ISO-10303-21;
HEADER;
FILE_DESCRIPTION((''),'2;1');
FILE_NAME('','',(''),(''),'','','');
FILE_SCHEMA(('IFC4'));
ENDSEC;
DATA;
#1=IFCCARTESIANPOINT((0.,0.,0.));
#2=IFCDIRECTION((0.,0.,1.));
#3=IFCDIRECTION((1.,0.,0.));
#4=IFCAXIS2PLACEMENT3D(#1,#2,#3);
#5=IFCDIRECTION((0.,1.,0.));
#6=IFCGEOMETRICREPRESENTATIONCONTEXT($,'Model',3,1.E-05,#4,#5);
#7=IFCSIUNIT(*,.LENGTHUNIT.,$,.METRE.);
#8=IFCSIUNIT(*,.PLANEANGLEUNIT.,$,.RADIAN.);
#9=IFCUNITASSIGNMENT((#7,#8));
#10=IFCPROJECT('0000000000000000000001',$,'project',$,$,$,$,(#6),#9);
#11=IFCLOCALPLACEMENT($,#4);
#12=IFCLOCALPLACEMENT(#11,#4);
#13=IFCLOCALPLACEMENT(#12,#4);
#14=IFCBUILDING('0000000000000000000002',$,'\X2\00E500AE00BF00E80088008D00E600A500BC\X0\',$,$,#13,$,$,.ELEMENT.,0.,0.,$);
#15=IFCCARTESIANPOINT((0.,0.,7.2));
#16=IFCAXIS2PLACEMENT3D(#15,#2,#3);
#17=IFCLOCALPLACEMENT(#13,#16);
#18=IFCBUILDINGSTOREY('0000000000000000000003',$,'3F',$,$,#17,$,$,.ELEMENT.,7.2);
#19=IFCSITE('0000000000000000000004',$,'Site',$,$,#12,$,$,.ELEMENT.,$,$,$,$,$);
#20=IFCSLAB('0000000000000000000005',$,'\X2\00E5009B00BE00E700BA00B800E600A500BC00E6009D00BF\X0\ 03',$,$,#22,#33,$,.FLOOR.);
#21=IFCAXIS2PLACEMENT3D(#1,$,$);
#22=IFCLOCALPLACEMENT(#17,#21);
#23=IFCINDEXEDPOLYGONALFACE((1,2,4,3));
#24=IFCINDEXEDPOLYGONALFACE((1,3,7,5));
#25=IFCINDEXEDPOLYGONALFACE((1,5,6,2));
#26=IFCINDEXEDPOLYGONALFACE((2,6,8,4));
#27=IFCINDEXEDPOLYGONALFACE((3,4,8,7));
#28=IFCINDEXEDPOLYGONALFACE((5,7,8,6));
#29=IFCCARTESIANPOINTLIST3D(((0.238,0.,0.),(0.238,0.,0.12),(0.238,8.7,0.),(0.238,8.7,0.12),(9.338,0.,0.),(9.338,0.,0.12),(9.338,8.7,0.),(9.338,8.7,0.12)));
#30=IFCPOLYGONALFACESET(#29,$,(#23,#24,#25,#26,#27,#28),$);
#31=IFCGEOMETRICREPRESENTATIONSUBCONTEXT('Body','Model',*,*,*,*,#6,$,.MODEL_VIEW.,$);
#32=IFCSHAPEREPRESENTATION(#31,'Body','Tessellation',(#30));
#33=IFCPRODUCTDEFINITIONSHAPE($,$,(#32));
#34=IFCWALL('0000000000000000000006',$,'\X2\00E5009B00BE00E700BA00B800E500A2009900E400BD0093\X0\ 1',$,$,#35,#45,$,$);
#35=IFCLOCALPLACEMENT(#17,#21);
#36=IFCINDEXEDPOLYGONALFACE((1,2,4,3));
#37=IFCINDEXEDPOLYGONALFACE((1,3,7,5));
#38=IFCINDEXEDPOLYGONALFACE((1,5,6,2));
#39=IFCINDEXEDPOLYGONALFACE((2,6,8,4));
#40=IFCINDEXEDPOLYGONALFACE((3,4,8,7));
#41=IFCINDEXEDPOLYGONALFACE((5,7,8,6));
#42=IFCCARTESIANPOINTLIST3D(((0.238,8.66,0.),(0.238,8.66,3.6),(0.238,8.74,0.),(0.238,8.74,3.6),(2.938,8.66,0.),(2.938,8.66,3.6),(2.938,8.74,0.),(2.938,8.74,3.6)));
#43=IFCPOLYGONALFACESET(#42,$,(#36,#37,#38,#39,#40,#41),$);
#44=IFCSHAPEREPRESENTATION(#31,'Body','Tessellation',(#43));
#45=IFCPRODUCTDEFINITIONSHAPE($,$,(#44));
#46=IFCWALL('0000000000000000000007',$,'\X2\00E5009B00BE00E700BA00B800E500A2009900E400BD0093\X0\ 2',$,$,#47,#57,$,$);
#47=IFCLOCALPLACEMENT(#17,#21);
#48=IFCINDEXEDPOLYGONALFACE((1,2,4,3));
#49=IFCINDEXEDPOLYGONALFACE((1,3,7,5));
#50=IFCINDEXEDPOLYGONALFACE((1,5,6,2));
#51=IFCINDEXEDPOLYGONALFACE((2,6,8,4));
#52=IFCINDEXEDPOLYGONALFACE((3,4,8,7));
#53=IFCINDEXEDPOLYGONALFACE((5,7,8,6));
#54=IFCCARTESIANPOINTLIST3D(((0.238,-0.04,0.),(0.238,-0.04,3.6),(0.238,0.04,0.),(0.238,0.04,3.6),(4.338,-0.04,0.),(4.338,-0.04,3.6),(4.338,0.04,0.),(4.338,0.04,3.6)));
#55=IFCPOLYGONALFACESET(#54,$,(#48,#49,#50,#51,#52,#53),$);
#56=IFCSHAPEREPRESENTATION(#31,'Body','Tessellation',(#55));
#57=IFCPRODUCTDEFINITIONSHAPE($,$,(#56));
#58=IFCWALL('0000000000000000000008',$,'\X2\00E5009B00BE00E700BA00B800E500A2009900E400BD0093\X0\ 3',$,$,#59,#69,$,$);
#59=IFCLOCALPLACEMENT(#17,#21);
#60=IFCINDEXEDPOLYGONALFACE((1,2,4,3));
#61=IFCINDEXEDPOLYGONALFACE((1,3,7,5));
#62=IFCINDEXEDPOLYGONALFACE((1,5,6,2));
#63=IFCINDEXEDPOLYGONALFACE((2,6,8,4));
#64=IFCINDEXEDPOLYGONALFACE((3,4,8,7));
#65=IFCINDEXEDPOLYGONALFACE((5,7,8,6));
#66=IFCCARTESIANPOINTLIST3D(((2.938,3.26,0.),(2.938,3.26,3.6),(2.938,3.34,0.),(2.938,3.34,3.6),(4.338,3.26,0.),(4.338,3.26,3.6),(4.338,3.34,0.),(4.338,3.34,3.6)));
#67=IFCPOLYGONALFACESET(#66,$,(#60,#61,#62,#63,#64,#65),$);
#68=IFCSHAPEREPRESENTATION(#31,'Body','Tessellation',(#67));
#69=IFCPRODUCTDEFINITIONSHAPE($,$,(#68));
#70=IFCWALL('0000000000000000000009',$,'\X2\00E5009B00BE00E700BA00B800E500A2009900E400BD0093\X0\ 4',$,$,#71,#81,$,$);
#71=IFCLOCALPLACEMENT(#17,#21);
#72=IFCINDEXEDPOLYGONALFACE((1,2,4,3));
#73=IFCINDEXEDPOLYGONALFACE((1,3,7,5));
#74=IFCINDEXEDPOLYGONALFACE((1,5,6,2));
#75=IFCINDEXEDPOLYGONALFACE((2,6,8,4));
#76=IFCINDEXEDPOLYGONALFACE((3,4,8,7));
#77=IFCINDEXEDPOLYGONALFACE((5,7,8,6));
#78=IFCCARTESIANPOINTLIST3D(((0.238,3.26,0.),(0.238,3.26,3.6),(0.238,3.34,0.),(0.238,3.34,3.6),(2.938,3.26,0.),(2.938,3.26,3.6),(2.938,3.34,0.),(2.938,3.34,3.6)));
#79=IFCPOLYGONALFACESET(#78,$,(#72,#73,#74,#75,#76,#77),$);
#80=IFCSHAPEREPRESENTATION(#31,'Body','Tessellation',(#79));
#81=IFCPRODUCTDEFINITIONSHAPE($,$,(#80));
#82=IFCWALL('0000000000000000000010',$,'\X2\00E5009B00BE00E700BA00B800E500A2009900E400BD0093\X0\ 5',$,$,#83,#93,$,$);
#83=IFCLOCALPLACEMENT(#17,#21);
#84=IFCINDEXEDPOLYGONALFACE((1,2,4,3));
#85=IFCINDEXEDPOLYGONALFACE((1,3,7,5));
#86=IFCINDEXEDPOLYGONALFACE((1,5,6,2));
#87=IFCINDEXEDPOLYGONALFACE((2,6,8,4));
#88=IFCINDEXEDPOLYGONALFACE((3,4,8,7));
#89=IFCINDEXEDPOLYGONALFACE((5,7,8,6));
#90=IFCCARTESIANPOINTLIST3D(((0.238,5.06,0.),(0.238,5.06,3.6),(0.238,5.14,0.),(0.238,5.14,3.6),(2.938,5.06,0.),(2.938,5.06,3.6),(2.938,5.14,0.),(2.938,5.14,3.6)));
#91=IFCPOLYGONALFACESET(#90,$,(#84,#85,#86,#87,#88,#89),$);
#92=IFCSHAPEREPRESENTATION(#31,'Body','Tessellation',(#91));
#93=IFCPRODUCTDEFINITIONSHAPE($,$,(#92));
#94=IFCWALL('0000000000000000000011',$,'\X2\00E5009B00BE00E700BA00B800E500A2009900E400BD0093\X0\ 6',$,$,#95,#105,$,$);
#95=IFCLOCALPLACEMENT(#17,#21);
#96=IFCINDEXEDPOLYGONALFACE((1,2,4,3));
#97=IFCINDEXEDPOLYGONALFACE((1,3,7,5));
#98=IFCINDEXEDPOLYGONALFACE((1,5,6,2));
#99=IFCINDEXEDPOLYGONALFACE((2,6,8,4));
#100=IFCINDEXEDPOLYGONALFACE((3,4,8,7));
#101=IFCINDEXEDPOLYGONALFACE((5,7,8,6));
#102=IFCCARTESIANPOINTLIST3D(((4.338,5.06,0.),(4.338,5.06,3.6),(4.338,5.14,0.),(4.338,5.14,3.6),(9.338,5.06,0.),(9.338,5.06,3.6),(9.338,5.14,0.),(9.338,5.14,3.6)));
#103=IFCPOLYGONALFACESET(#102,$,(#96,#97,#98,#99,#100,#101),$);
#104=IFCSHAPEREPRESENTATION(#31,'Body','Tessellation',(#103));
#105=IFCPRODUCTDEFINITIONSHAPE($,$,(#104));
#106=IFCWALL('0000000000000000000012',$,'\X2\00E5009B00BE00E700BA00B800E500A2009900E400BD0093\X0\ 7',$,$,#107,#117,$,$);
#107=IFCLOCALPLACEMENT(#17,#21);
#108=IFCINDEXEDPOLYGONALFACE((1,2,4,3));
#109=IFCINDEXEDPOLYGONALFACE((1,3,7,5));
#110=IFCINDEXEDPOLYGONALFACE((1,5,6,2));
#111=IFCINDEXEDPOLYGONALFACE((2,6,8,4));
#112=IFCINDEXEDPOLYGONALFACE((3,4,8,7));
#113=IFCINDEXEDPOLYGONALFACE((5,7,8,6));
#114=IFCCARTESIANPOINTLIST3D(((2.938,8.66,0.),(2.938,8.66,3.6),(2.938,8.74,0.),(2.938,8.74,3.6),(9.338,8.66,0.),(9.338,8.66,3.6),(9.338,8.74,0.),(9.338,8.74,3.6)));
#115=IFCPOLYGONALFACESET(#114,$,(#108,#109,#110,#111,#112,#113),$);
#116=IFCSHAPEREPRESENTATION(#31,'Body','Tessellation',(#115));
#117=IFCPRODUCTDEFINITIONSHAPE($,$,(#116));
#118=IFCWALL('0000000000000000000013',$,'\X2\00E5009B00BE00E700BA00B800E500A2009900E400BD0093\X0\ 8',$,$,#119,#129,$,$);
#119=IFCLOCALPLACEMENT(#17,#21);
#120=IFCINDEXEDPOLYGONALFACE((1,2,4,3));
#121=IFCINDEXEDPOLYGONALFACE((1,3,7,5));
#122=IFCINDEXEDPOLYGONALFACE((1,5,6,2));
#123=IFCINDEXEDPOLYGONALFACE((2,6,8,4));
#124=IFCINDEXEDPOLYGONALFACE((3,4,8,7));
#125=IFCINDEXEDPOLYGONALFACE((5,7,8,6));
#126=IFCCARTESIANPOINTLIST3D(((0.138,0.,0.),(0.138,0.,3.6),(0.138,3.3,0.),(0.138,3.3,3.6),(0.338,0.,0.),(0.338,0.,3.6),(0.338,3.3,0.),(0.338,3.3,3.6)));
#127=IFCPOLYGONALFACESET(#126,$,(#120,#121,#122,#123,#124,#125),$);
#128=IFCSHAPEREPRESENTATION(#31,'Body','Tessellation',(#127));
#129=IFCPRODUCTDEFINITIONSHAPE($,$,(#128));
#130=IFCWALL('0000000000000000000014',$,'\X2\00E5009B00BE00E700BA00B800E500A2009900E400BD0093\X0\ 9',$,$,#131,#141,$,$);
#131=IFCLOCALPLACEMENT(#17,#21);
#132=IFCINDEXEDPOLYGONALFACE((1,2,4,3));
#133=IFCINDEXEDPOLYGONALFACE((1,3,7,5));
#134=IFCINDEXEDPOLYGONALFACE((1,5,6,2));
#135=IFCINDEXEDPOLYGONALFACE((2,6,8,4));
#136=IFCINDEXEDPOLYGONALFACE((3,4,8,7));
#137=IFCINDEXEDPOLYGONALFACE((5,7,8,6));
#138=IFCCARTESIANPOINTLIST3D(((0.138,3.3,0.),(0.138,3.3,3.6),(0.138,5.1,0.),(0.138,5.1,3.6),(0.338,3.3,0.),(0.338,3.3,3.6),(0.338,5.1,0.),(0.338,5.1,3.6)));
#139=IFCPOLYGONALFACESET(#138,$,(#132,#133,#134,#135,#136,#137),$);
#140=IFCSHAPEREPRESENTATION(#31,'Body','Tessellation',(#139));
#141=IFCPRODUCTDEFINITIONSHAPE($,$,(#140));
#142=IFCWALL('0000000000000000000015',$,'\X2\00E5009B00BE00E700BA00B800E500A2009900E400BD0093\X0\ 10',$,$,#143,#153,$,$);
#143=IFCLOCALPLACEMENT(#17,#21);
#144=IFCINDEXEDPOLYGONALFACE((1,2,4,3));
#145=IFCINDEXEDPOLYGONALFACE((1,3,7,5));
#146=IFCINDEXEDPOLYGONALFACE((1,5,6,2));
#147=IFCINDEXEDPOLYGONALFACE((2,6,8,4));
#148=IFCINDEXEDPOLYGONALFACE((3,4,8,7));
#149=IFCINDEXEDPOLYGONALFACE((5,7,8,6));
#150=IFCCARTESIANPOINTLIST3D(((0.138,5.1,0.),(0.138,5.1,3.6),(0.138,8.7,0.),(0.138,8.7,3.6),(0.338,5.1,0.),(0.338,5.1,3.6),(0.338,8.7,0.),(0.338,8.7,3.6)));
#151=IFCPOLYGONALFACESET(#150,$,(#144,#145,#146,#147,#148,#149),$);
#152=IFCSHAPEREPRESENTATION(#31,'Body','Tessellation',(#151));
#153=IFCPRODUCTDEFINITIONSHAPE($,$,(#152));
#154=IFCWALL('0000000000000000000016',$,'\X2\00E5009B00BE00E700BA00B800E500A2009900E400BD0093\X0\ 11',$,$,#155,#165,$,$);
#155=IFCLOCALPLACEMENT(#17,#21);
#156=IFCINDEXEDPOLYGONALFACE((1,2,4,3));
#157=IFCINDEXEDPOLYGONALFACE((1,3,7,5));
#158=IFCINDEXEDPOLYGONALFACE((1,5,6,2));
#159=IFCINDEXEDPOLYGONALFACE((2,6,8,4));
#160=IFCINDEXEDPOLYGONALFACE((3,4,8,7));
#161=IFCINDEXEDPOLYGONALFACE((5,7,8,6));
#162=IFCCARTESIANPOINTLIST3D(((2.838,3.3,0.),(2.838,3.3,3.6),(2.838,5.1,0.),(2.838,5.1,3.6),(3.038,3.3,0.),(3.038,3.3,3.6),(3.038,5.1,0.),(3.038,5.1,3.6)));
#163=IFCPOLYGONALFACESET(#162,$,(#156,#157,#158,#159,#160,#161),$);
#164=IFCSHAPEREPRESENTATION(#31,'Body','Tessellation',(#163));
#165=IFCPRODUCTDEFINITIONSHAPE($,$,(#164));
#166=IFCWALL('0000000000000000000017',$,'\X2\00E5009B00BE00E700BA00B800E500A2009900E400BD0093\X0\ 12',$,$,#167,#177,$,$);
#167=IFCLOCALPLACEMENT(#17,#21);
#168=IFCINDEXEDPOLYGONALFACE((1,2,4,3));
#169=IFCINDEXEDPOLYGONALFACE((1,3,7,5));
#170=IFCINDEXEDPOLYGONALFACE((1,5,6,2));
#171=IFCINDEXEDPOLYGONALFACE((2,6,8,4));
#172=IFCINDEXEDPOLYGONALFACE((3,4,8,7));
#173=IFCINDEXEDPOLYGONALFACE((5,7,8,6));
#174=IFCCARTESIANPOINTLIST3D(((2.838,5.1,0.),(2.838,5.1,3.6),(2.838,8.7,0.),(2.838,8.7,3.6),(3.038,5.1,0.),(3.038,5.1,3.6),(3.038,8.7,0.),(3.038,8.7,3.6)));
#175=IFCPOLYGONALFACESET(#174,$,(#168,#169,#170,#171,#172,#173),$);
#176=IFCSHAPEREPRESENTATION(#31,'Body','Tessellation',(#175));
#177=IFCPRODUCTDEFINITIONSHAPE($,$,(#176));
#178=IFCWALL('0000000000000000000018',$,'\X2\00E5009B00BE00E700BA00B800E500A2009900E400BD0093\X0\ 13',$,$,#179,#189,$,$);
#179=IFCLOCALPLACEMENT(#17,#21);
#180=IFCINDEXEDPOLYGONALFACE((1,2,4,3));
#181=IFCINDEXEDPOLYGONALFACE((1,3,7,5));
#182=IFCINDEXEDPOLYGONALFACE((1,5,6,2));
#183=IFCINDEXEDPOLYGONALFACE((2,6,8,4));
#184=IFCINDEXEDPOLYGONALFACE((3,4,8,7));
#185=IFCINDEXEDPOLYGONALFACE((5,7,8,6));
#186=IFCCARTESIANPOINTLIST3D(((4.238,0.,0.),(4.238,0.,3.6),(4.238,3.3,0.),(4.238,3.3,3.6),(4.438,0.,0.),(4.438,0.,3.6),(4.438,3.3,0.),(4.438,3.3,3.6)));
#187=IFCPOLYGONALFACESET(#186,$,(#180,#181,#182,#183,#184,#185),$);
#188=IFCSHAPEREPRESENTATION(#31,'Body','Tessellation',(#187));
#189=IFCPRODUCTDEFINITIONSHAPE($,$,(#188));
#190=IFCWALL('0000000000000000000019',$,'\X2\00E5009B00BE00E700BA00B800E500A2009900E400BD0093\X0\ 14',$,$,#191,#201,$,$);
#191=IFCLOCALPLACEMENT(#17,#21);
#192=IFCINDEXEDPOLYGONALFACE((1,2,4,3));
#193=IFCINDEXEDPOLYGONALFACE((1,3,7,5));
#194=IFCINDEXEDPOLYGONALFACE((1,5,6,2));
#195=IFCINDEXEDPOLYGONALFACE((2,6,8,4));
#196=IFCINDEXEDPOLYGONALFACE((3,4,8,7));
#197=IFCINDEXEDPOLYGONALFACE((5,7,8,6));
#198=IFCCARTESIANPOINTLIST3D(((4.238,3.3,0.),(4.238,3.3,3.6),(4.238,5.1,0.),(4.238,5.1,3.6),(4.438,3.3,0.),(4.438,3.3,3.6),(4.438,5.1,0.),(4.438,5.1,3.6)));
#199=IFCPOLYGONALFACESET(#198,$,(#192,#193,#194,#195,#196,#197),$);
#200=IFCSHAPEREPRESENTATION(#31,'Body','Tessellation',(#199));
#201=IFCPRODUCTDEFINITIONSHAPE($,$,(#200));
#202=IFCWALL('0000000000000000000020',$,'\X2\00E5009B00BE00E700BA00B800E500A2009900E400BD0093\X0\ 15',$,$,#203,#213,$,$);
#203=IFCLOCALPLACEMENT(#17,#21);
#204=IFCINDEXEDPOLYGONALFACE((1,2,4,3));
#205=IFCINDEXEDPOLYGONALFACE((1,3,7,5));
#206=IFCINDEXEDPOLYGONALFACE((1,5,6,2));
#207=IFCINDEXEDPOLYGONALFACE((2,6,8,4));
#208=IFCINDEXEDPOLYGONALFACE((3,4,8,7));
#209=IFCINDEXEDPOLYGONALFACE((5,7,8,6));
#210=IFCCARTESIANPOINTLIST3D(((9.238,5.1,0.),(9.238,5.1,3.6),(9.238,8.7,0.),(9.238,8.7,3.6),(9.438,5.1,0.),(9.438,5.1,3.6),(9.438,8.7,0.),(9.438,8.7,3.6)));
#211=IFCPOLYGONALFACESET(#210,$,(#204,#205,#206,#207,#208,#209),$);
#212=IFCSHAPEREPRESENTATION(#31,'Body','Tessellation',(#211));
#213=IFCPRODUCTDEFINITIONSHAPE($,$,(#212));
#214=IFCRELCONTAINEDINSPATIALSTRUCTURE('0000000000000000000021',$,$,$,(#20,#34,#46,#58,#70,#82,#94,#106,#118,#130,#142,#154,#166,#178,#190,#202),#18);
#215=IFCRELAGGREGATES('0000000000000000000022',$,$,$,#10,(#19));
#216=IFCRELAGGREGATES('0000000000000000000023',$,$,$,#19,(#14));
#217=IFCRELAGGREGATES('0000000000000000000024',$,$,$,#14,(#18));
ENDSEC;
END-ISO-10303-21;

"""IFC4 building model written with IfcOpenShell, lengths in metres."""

from ifc_helpers import new_model, si_unit, direction, frame, frame_2d, origin_with_axes, place, context, subcontext, project, spatial, rectangle, extrude, element, save


model = new_model("IFC4")

# Units and contexts
model_context = context("Model", 3, precision=1e-05, world=origin_with_axes(), true_north=direction((0.0, 1.0, 0.0)))
body_context = subcontext(model_context, "Body", "Model", "MODEL_VIEW")
ifc_project = project(units=[si_unit("LENGTHUNIT", "METRE"), si_unit("PLANEANGLEUNIT", "RADIAN")], contexts=[model_context])

# Site, building, storey
placement = place(None, origin_with_axes())
site_placement = place(placement, origin_with_axes())
site = spatial("IfcSite", under=ifc_project, at=site_placement, Name="Site", CompositionType="ELEMENT")
building_placement = place(site_placement, origin_with_axes())
building = spatial("IfcBuilding", under=site, at=building_placement, Name="å®¿è\u0088\u008dæ¥¼", CompositionType="ELEMENT", ElevationOfRefHeight=0.0, ElevationOfTerrain=0.0)
storey_placement = place(building_placement, frame((0.0, 0.0, 7.2), z_axis=(0.0, 0.0, 1.0), x_axis=(1.0, 0.0, 0.0)))
storey = spatial("IfcBuildingStorey", under=building, at=storey_placement, Name="3F", CompositionType="ELEMENT", Elevation=7.2)

# Slab
slab_placement = place(storey_placement, frame((4.788, 4.35, 0.0), z_axis=(0.0, 0.0, 1.0), x_axis=(1.0, 0.0, 0.0)))
element("IfcSlab", 1, at=slab_placement, inside=storey, Name="å\u009b¾çº¸æ¥¼æ\u009d¿ 03", PredefinedType="FLOOR", context=body_context, shape_type="SweptSolid", body=[
    extrude(rectangle(XDim=9.1, YDim=8.7, at=frame_2d((0.0, 0.0), x_axis=(1.0, 0.0, 0.0))), frame((0.0, 0.0, 0.0), z_axis=(0.0, 0.0, 1.0)), (0.0, 0.0, 1.0), 0.12),
])

# Walls
wall_1_placement = place(storey_placement, frame((1.588, 8.7, 0.0), z_axis=(0.0, 0.0, 1.0), x_axis=(1.0, 0.0, 0.0)))
element("IfcWall", 2, at=wall_1_placement, inside=storey, Name="å\u009b¾çº¸å¢\u0099ä½\u0093 1", context=body_context, shape_type="SweptSolid", body=[
    extrude(rectangle(XDim=2.7, YDim=0.0801, at=frame_2d((0.0, 0.0), x_axis=(1.0, 0.0, 0.0))), frame((0.0, 0.0, 0.0), z_axis=(0.0, 0.0, 1.0)), (0.0, 0.0, 1.0), 3.6),
])
wall_2_placement = place(storey_placement, frame((2.288, 0.0, 0.0), z_axis=(0.0, 0.0, 1.0), x_axis=(1.0, 0.0, 0.0)))
element("IfcWall", 3, at=wall_2_placement, inside=storey, Name="å\u009b¾çº¸å¢\u0099ä½\u0093 2", context=body_context, shape_type="SweptSolid", body=[
    extrude(rectangle(XDim=4.1, YDim=0.0801, at=frame_2d((0.0, 0.0), x_axis=(1.0, 0.0, 0.0))), frame((0.0, 0.0, 0.0), z_axis=(0.0, 0.0, 1.0)), (0.0, 0.0, 1.0), 3.6),
])
wall_3_placement = place(storey_placement, frame((3.638, 3.3, 0.0), z_axis=(0.0, 0.0, 1.0), x_axis=(1.0, 0.0, 0.0)))
element("IfcWall", 4, at=wall_3_placement, inside=storey, Name="å\u009b¾çº¸å¢\u0099ä½\u0093 3", context=body_context, shape_type="SweptSolid", body=[
    extrude(rectangle(XDim=1.4, YDim=0.0801, at=frame_2d((0.0, 0.0), x_axis=(1.0, 0.0, 0.0))), frame((0.0, 0.0, 0.0), z_axis=(0.0, 0.0, 1.0)), (0.0, 0.0, 1.0), 3.6),
])
for number, where, z_axis, x_axis, name in (
    (5, (1.588, 3.3, 0.0), (0.0, 0.0, 1.0), (1.0, 0.0, 0.0), "å\u009b¾çº¸å¢\u0099ä½\u0093 4"),
    (6, (1.588, 5.1, 0.0), (0.0, 0.0, 1.0), (1.0, 0.0, 0.0), "å\u009b¾çº¸å¢\u0099ä½\u0093 5"),
):
    element("IfcWall", number, at=place(storey_placement, frame(where, z_axis=z_axis, x_axis=x_axis)), inside=storey, Name=name, context=body_context, shape_type="SweptSolid", body=[
        extrude(rectangle(XDim=2.7, YDim=0.0801, at=frame_2d((0.0, 0.0), x_axis=(1.0, 0.0, 0.0))), frame((0.0, 0.0, 0.0), z_axis=(0.0, 0.0, 1.0)), (0.0, 0.0, 1.0), 3.6),
    ])
wall_4_placement = place(storey_placement, frame((6.838, 5.1, 0.0), z_axis=(0.0, 0.0, 1.0), x_axis=(1.0, 0.0, 0.0)))
element("IfcWall", 7, at=wall_4_placement, inside=storey, Name="å\u009b¾çº¸å¢\u0099ä½\u0093 6", context=body_context, shape_type="SweptSolid", body=[
    extrude(rectangle(XDim=5.0, YDim=0.0801, at=frame_2d((0.0, 0.0), x_axis=(1.0, 0.0, 0.0))), frame((0.0, 0.0, 0.0), z_axis=(0.0, 0.0, 1.0)), (0.0, 0.0, 1.0), 3.6),
])
wall_5_placement = place(storey_placement, frame((6.138, 8.7, 0.0), z_axis=(0.0, 0.0, 1.0), x_axis=(-1.0, 0.0, 0.0)))
element("IfcWall", 8, at=wall_5_placement, inside=storey, Name="å\u009b¾çº¸å¢\u0099ä½\u0093 7", context=body_context, shape_type="SweptSolid", body=[
    extrude(rectangle(XDim=6.4, YDim=0.0801, at=frame_2d((0.0, 0.0), x_axis=(1.0, 0.0, 0.0))), frame((0.0, 0.0, 0.0), z_axis=(0.0, 0.0, 1.0)), (0.0, 0.0, 1.0), 3.6),
])
wall_6_placement = place(storey_placement, frame((0.238, 1.65, 0.0), z_axis=(0.0, 0.0, 1.0), x_axis=(0.0, 1.0, 0.0)))
element("IfcWall", 9, at=wall_6_placement, inside=storey, Name="å\u009b¾çº¸å¢\u0099ä½\u0093 8", context=body_context, shape_type="SweptSolid", body=[
    extrude(rectangle(XDim=3.3, YDim=0.2, at=frame_2d((0.0, 0.0), x_axis=(1.0, 0.0, 0.0))), frame((0.0, 0.0, 0.0), z_axis=(0.0, 0.0, 1.0)), (0.0, 0.0, 1.0), 3.6),
])
wall_7_placement = place(storey_placement, frame((0.238, 4.2, 0.0), z_axis=(0.0, 0.0, 1.0), x_axis=(0.0, 1.0, 0.0)))
element("IfcWall", 10, at=wall_7_placement, inside=storey, Name="å\u009b¾çº¸å¢\u0099ä½\u0093 9", context=body_context, shape_type="SweptSolid", body=[
    extrude(rectangle(XDim=1.8, YDim=0.2, at=frame_2d((0.0, 0.0), x_axis=(1.0, 0.0, 0.0))), frame((0.0, 0.0, 0.0), z_axis=(0.0, 0.0, 1.0)), (0.0, 0.0, 1.0), 3.6),
])
wall_8_placement = place(storey_placement, frame((0.238, 6.9, 0.0), z_axis=(0.0, 0.0, 1.0), x_axis=(0.0, 1.0, 0.0)))
element("IfcWall", 11, at=wall_8_placement, inside=storey, Name="å\u009b¾çº¸å¢\u0099ä½\u0093 10", context=body_context, shape_type="SweptSolid", body=[
    extrude(rectangle(XDim=3.6, YDim=0.2, at=frame_2d((0.0, 0.0), x_axis=(1.0, 0.0, 0.0))), frame((0.0, 0.0, 0.0), z_axis=(0.0, 0.0, 1.0)), (0.0, 0.0, 1.0), 3.6),
])
wall_9_placement = place(storey_placement, frame((2.938, 4.2, 0.0), z_axis=(0.0, 0.0, 1.0), x_axis=(0.0, 1.0, 0.0)))
element("IfcWall", 12, at=wall_9_placement, inside=storey, Name="å\u009b¾çº¸å¢\u0099ä½\u0093 11", context=body_context, shape_type="SweptSolid", body=[
    extrude(rectangle(XDim=1.8, YDim=0.2, at=frame_2d((0.0, 0.0), x_axis=(1.0, 0.0, 0.0))), frame((0.0, 0.0, 0.0), z_axis=(0.0, 0.0, 1.0)), (0.0, 0.0, 1.0), 3.6),
])
wall_10_placement = place(storey_placement, frame((2.938, 6.9, 0.0), z_axis=(0.0, 0.0, 1.0), x_axis=(0.0, 1.0, 0.0)))
element("IfcWall", 13, at=wall_10_placement, inside=storey, Name="å\u009b¾çº¸å¢\u0099ä½\u0093 12", context=body_context, shape_type="SweptSolid", body=[
    extrude(rectangle(XDim=3.6, YDim=0.2, at=frame_2d((0.0, 0.0), x_axis=(1.0, 0.0, 0.0))), frame((0.0, 0.0, 0.0), z_axis=(0.0, 0.0, 1.0)), (0.0, 0.0, 1.0), 3.6),
])
wall_11_placement = place(storey_placement, frame((4.338, 1.65, 0.0), z_axis=(0.0, 0.0, 1.0), x_axis=(0.0, 1.0, 0.0)))
element("IfcWall", 14, at=wall_11_placement, inside=storey, Name="å\u009b¾çº¸å¢\u0099ä½\u0093 13", context=body_context, shape_type="SweptSolid", body=[
    extrude(rectangle(XDim=3.3, YDim=0.2, at=frame_2d((0.0, 0.0), x_axis=(1.0, 0.0, 0.0))), frame((0.0, 0.0, 0.0), z_axis=(0.0, 0.0, 1.0)), (0.0, 0.0, 1.0), 3.6),
])
wall_12_placement = place(storey_placement, frame((4.338, 4.2, 0.0), z_axis=(0.0, 0.0, 1.0), x_axis=(0.0, 1.0, 0.0)))
element("IfcWall", 15, at=wall_12_placement, inside=storey, Name="å\u009b¾çº¸å¢\u0099ä½\u0093 14", context=body_context, shape_type="SweptSolid", body=[
    extrude(rectangle(XDim=1.8, YDim=0.2, at=frame_2d((0.0, 0.0), x_axis=(1.0, 0.0, 0.0))), frame((0.0, 0.0, 0.0), z_axis=(0.0, 0.0, 1.0)), (0.0, 0.0, 1.0), 3.6),
])
wall_13_placement = place(storey_placement, frame((9.338, 6.9, 0.0), z_axis=(0.0, 0.0, 1.0), x_axis=(0.0, 1.0, 0.0)))
element("IfcWall", 16, at=wall_13_placement, inside=storey, Name="å\u009b¾çº¸å¢\u0099ä½\u0093 15", context=body_context, shape_type="SweptSolid", body=[
    extrude(rectangle(XDim=3.6, YDim=0.2, at=frame_2d((0.0, 0.0), x_axis=(1.0, 0.0, 0.0))), frame((0.0, 0.0, 0.0), z_axis=(0.0, 0.0, 1.0)), (0.0, 0.0, 1.0), 3.6),
])

save(model, "model.ifc")
